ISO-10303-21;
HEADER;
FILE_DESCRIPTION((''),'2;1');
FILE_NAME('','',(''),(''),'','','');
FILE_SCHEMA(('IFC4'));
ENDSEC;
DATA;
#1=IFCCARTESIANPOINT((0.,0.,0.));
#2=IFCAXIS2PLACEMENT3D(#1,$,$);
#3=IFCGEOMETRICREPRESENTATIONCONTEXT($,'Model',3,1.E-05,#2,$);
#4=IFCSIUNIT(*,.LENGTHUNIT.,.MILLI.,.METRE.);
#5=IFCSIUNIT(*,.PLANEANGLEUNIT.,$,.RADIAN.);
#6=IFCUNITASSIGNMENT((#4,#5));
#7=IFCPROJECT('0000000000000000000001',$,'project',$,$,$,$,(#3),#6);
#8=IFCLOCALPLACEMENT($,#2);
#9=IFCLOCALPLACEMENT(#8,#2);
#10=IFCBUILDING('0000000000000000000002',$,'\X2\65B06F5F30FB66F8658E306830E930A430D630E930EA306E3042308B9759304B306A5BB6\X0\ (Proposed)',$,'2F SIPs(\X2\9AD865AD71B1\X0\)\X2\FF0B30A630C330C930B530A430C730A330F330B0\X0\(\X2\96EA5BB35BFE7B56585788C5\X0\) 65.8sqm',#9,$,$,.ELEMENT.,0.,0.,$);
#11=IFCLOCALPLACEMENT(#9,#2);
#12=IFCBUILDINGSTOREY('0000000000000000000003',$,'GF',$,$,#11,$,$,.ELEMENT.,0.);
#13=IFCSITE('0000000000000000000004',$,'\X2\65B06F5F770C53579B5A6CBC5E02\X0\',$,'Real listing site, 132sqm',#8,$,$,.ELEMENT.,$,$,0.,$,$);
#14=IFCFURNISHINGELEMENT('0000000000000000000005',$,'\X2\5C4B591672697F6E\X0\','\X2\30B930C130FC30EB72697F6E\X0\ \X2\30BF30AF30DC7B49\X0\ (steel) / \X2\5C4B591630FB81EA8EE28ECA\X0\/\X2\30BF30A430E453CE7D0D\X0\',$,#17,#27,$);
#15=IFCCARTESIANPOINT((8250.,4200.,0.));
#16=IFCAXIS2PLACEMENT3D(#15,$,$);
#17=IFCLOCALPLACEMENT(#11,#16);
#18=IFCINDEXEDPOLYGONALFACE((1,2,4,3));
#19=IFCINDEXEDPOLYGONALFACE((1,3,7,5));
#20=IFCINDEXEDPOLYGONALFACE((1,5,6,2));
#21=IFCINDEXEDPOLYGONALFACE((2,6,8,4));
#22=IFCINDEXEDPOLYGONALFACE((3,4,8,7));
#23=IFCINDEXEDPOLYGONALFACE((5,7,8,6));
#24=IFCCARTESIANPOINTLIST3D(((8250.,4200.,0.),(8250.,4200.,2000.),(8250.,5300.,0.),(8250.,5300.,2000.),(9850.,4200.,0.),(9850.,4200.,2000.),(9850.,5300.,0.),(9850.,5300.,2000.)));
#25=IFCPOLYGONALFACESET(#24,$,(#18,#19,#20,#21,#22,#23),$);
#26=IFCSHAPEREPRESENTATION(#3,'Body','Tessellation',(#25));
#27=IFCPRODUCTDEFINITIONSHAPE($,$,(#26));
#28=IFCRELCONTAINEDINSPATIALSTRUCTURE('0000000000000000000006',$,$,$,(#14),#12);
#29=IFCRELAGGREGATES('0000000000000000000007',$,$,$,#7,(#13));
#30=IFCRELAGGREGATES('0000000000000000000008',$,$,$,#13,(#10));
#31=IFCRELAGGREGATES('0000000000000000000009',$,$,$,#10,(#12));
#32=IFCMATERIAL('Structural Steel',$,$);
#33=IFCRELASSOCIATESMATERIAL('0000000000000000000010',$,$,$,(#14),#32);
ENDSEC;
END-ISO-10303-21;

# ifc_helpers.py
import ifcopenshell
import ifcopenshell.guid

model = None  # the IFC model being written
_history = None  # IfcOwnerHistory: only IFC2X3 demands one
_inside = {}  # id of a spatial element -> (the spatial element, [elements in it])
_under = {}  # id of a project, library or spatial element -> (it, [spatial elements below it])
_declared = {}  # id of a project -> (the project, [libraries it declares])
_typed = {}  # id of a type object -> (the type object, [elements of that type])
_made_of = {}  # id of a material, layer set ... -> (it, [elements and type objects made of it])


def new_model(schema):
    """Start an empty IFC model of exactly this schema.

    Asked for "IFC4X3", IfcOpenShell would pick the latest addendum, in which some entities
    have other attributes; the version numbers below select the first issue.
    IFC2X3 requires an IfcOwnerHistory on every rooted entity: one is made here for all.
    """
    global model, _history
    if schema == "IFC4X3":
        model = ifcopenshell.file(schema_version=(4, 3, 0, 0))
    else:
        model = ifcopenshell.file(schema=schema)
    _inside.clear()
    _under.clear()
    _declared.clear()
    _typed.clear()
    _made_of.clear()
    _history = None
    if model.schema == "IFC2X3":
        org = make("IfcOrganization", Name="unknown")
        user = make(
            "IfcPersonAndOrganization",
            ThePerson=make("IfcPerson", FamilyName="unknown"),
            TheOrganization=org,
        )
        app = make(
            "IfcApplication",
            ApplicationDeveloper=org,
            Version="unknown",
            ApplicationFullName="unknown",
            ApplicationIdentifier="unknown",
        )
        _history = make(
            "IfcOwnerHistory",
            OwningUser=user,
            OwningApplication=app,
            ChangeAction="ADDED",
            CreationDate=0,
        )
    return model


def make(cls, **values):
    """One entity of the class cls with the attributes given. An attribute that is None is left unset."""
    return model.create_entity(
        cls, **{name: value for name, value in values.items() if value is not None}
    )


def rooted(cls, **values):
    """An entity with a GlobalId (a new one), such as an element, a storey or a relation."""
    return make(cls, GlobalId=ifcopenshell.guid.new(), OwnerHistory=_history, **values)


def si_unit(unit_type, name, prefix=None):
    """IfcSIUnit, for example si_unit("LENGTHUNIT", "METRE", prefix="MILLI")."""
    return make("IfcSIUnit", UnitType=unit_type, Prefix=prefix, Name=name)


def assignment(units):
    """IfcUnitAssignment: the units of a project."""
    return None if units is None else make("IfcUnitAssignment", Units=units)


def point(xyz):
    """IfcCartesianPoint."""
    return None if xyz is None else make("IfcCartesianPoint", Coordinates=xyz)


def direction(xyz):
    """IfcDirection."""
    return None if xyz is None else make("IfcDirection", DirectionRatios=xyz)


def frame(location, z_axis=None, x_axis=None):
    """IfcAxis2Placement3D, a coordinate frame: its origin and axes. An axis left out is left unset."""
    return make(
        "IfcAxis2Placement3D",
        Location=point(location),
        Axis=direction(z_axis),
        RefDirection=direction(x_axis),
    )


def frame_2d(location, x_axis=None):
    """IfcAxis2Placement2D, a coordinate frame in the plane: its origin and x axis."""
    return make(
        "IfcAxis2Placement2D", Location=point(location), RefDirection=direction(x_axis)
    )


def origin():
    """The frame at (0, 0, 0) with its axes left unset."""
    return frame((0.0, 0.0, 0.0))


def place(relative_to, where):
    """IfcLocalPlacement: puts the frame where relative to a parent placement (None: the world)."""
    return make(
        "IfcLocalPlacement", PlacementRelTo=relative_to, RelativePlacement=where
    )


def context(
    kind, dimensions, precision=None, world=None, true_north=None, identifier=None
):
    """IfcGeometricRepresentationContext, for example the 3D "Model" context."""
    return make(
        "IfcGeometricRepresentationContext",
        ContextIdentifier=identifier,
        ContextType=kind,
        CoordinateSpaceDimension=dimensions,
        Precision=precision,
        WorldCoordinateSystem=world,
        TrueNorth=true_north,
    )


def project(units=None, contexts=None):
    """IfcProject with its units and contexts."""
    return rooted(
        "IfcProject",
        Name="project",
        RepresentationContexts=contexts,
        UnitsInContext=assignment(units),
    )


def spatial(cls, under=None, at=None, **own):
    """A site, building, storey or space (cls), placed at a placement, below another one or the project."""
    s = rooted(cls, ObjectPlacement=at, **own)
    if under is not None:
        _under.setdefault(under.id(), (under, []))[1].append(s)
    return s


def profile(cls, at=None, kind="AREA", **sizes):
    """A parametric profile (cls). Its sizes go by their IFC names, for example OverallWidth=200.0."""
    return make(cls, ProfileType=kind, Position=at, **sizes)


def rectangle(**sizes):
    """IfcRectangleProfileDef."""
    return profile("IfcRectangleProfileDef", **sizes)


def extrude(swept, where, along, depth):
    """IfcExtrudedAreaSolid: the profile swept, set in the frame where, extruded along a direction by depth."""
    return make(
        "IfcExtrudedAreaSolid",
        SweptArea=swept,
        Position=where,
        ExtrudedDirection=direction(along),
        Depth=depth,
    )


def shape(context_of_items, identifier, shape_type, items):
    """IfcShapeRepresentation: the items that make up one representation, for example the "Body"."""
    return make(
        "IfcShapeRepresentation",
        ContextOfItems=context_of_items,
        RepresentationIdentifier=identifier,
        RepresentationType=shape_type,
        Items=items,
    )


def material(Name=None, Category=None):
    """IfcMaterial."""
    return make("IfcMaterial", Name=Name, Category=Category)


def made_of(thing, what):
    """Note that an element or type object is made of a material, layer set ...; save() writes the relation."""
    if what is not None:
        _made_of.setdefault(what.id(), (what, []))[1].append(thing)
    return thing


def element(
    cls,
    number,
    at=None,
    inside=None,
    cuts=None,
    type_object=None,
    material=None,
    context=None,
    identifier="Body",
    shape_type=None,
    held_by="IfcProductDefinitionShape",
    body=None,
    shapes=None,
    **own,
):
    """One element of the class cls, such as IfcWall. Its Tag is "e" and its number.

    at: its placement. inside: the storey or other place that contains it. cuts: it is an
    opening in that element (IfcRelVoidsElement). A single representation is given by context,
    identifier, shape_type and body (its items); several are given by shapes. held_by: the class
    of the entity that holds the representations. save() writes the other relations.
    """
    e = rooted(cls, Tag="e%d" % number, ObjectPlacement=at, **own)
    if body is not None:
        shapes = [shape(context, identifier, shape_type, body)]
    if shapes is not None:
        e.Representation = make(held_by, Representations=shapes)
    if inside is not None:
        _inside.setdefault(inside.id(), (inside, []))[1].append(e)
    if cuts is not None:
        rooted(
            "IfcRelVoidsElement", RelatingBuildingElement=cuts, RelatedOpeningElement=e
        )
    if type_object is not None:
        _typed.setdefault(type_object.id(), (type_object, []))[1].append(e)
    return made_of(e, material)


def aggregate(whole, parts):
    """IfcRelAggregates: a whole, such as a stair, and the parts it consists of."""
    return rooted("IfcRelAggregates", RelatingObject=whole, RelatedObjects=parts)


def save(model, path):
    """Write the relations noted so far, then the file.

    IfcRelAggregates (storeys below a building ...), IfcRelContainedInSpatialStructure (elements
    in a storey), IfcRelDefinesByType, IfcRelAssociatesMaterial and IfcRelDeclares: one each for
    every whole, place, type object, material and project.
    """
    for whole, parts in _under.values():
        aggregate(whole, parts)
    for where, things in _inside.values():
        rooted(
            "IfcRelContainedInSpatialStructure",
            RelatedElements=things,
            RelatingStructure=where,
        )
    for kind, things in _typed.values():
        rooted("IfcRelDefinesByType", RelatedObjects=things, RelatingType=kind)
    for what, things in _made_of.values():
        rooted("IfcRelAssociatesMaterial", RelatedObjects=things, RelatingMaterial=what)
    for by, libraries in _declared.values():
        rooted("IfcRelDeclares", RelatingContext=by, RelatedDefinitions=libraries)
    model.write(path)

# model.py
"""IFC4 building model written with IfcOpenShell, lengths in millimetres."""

from ifc_helpers import new_model, si_unit, frame, frame_2d, origin, place, context, project, spatial, rectangle, extrude, material, element, save


model = new_model("IFC4")

# Units and contexts
model_context = context("Model", 3, precision=1e-05, world=origin())
ifc_project = project(units=[si_unit("LENGTHUNIT", "METRE", prefix="MILLI"), si_unit("PLANEANGLEUNIT", "RADIAN")], contexts=[model_context])

# Site, building, storey
site_placement = place(None, origin())
site = spatial("IfcSite", under=ifc_project, at=site_placement, Name="新潟県南魚沼市", ObjectType="Real listing site, 132sqm", CompositionType="ELEMENT", RefElevation=0.0)
building_placement = place(site_placement, origin())
building = spatial("IfcBuilding", under=site, at=building_placement, Name="新潟・書斎とライブラリのある静かな家 (Proposed)", ObjectType="2F SIPs(高断熱)＋ウッドサイディング(雪害対策塗装) 65.8sqm", CompositionType="ELEMENT", ElevationOfRefHeight=0.0, ElevationOfTerrain=0.0)
storey_placement = place(building_placement, origin())
storey = spatial("IfcBuildingStorey", under=building, at=storey_placement, Name="GF", CompositionType="ELEMENT", Elevation=0.0)

# Shared definitions
ifc_material_1 = material(Name="Structural Steel")

# Furnishing element
furnishing_1_placement = place(storey_placement, frame((8250.0, 4200.0, 0.0)))
element("IfcFurnishingElement", 1, at=furnishing_1_placement, inside=storey, material=ifc_material_1, Name="屋外物置", Description="スチール物置 タクボ等 (steel) / 屋外・自転車/タイヤ収納", context=model_context, shape_type="SweptSolid", body=[
    extrude(rectangle(XDim=1600.0, YDim=1100.0, at=frame_2d((800.0, 550.0))), frame((8250.0, 4200.0, 0.0)), (0.0, 0.0, 1.0), 2000.0),
])

save(model, "model.ifc")
